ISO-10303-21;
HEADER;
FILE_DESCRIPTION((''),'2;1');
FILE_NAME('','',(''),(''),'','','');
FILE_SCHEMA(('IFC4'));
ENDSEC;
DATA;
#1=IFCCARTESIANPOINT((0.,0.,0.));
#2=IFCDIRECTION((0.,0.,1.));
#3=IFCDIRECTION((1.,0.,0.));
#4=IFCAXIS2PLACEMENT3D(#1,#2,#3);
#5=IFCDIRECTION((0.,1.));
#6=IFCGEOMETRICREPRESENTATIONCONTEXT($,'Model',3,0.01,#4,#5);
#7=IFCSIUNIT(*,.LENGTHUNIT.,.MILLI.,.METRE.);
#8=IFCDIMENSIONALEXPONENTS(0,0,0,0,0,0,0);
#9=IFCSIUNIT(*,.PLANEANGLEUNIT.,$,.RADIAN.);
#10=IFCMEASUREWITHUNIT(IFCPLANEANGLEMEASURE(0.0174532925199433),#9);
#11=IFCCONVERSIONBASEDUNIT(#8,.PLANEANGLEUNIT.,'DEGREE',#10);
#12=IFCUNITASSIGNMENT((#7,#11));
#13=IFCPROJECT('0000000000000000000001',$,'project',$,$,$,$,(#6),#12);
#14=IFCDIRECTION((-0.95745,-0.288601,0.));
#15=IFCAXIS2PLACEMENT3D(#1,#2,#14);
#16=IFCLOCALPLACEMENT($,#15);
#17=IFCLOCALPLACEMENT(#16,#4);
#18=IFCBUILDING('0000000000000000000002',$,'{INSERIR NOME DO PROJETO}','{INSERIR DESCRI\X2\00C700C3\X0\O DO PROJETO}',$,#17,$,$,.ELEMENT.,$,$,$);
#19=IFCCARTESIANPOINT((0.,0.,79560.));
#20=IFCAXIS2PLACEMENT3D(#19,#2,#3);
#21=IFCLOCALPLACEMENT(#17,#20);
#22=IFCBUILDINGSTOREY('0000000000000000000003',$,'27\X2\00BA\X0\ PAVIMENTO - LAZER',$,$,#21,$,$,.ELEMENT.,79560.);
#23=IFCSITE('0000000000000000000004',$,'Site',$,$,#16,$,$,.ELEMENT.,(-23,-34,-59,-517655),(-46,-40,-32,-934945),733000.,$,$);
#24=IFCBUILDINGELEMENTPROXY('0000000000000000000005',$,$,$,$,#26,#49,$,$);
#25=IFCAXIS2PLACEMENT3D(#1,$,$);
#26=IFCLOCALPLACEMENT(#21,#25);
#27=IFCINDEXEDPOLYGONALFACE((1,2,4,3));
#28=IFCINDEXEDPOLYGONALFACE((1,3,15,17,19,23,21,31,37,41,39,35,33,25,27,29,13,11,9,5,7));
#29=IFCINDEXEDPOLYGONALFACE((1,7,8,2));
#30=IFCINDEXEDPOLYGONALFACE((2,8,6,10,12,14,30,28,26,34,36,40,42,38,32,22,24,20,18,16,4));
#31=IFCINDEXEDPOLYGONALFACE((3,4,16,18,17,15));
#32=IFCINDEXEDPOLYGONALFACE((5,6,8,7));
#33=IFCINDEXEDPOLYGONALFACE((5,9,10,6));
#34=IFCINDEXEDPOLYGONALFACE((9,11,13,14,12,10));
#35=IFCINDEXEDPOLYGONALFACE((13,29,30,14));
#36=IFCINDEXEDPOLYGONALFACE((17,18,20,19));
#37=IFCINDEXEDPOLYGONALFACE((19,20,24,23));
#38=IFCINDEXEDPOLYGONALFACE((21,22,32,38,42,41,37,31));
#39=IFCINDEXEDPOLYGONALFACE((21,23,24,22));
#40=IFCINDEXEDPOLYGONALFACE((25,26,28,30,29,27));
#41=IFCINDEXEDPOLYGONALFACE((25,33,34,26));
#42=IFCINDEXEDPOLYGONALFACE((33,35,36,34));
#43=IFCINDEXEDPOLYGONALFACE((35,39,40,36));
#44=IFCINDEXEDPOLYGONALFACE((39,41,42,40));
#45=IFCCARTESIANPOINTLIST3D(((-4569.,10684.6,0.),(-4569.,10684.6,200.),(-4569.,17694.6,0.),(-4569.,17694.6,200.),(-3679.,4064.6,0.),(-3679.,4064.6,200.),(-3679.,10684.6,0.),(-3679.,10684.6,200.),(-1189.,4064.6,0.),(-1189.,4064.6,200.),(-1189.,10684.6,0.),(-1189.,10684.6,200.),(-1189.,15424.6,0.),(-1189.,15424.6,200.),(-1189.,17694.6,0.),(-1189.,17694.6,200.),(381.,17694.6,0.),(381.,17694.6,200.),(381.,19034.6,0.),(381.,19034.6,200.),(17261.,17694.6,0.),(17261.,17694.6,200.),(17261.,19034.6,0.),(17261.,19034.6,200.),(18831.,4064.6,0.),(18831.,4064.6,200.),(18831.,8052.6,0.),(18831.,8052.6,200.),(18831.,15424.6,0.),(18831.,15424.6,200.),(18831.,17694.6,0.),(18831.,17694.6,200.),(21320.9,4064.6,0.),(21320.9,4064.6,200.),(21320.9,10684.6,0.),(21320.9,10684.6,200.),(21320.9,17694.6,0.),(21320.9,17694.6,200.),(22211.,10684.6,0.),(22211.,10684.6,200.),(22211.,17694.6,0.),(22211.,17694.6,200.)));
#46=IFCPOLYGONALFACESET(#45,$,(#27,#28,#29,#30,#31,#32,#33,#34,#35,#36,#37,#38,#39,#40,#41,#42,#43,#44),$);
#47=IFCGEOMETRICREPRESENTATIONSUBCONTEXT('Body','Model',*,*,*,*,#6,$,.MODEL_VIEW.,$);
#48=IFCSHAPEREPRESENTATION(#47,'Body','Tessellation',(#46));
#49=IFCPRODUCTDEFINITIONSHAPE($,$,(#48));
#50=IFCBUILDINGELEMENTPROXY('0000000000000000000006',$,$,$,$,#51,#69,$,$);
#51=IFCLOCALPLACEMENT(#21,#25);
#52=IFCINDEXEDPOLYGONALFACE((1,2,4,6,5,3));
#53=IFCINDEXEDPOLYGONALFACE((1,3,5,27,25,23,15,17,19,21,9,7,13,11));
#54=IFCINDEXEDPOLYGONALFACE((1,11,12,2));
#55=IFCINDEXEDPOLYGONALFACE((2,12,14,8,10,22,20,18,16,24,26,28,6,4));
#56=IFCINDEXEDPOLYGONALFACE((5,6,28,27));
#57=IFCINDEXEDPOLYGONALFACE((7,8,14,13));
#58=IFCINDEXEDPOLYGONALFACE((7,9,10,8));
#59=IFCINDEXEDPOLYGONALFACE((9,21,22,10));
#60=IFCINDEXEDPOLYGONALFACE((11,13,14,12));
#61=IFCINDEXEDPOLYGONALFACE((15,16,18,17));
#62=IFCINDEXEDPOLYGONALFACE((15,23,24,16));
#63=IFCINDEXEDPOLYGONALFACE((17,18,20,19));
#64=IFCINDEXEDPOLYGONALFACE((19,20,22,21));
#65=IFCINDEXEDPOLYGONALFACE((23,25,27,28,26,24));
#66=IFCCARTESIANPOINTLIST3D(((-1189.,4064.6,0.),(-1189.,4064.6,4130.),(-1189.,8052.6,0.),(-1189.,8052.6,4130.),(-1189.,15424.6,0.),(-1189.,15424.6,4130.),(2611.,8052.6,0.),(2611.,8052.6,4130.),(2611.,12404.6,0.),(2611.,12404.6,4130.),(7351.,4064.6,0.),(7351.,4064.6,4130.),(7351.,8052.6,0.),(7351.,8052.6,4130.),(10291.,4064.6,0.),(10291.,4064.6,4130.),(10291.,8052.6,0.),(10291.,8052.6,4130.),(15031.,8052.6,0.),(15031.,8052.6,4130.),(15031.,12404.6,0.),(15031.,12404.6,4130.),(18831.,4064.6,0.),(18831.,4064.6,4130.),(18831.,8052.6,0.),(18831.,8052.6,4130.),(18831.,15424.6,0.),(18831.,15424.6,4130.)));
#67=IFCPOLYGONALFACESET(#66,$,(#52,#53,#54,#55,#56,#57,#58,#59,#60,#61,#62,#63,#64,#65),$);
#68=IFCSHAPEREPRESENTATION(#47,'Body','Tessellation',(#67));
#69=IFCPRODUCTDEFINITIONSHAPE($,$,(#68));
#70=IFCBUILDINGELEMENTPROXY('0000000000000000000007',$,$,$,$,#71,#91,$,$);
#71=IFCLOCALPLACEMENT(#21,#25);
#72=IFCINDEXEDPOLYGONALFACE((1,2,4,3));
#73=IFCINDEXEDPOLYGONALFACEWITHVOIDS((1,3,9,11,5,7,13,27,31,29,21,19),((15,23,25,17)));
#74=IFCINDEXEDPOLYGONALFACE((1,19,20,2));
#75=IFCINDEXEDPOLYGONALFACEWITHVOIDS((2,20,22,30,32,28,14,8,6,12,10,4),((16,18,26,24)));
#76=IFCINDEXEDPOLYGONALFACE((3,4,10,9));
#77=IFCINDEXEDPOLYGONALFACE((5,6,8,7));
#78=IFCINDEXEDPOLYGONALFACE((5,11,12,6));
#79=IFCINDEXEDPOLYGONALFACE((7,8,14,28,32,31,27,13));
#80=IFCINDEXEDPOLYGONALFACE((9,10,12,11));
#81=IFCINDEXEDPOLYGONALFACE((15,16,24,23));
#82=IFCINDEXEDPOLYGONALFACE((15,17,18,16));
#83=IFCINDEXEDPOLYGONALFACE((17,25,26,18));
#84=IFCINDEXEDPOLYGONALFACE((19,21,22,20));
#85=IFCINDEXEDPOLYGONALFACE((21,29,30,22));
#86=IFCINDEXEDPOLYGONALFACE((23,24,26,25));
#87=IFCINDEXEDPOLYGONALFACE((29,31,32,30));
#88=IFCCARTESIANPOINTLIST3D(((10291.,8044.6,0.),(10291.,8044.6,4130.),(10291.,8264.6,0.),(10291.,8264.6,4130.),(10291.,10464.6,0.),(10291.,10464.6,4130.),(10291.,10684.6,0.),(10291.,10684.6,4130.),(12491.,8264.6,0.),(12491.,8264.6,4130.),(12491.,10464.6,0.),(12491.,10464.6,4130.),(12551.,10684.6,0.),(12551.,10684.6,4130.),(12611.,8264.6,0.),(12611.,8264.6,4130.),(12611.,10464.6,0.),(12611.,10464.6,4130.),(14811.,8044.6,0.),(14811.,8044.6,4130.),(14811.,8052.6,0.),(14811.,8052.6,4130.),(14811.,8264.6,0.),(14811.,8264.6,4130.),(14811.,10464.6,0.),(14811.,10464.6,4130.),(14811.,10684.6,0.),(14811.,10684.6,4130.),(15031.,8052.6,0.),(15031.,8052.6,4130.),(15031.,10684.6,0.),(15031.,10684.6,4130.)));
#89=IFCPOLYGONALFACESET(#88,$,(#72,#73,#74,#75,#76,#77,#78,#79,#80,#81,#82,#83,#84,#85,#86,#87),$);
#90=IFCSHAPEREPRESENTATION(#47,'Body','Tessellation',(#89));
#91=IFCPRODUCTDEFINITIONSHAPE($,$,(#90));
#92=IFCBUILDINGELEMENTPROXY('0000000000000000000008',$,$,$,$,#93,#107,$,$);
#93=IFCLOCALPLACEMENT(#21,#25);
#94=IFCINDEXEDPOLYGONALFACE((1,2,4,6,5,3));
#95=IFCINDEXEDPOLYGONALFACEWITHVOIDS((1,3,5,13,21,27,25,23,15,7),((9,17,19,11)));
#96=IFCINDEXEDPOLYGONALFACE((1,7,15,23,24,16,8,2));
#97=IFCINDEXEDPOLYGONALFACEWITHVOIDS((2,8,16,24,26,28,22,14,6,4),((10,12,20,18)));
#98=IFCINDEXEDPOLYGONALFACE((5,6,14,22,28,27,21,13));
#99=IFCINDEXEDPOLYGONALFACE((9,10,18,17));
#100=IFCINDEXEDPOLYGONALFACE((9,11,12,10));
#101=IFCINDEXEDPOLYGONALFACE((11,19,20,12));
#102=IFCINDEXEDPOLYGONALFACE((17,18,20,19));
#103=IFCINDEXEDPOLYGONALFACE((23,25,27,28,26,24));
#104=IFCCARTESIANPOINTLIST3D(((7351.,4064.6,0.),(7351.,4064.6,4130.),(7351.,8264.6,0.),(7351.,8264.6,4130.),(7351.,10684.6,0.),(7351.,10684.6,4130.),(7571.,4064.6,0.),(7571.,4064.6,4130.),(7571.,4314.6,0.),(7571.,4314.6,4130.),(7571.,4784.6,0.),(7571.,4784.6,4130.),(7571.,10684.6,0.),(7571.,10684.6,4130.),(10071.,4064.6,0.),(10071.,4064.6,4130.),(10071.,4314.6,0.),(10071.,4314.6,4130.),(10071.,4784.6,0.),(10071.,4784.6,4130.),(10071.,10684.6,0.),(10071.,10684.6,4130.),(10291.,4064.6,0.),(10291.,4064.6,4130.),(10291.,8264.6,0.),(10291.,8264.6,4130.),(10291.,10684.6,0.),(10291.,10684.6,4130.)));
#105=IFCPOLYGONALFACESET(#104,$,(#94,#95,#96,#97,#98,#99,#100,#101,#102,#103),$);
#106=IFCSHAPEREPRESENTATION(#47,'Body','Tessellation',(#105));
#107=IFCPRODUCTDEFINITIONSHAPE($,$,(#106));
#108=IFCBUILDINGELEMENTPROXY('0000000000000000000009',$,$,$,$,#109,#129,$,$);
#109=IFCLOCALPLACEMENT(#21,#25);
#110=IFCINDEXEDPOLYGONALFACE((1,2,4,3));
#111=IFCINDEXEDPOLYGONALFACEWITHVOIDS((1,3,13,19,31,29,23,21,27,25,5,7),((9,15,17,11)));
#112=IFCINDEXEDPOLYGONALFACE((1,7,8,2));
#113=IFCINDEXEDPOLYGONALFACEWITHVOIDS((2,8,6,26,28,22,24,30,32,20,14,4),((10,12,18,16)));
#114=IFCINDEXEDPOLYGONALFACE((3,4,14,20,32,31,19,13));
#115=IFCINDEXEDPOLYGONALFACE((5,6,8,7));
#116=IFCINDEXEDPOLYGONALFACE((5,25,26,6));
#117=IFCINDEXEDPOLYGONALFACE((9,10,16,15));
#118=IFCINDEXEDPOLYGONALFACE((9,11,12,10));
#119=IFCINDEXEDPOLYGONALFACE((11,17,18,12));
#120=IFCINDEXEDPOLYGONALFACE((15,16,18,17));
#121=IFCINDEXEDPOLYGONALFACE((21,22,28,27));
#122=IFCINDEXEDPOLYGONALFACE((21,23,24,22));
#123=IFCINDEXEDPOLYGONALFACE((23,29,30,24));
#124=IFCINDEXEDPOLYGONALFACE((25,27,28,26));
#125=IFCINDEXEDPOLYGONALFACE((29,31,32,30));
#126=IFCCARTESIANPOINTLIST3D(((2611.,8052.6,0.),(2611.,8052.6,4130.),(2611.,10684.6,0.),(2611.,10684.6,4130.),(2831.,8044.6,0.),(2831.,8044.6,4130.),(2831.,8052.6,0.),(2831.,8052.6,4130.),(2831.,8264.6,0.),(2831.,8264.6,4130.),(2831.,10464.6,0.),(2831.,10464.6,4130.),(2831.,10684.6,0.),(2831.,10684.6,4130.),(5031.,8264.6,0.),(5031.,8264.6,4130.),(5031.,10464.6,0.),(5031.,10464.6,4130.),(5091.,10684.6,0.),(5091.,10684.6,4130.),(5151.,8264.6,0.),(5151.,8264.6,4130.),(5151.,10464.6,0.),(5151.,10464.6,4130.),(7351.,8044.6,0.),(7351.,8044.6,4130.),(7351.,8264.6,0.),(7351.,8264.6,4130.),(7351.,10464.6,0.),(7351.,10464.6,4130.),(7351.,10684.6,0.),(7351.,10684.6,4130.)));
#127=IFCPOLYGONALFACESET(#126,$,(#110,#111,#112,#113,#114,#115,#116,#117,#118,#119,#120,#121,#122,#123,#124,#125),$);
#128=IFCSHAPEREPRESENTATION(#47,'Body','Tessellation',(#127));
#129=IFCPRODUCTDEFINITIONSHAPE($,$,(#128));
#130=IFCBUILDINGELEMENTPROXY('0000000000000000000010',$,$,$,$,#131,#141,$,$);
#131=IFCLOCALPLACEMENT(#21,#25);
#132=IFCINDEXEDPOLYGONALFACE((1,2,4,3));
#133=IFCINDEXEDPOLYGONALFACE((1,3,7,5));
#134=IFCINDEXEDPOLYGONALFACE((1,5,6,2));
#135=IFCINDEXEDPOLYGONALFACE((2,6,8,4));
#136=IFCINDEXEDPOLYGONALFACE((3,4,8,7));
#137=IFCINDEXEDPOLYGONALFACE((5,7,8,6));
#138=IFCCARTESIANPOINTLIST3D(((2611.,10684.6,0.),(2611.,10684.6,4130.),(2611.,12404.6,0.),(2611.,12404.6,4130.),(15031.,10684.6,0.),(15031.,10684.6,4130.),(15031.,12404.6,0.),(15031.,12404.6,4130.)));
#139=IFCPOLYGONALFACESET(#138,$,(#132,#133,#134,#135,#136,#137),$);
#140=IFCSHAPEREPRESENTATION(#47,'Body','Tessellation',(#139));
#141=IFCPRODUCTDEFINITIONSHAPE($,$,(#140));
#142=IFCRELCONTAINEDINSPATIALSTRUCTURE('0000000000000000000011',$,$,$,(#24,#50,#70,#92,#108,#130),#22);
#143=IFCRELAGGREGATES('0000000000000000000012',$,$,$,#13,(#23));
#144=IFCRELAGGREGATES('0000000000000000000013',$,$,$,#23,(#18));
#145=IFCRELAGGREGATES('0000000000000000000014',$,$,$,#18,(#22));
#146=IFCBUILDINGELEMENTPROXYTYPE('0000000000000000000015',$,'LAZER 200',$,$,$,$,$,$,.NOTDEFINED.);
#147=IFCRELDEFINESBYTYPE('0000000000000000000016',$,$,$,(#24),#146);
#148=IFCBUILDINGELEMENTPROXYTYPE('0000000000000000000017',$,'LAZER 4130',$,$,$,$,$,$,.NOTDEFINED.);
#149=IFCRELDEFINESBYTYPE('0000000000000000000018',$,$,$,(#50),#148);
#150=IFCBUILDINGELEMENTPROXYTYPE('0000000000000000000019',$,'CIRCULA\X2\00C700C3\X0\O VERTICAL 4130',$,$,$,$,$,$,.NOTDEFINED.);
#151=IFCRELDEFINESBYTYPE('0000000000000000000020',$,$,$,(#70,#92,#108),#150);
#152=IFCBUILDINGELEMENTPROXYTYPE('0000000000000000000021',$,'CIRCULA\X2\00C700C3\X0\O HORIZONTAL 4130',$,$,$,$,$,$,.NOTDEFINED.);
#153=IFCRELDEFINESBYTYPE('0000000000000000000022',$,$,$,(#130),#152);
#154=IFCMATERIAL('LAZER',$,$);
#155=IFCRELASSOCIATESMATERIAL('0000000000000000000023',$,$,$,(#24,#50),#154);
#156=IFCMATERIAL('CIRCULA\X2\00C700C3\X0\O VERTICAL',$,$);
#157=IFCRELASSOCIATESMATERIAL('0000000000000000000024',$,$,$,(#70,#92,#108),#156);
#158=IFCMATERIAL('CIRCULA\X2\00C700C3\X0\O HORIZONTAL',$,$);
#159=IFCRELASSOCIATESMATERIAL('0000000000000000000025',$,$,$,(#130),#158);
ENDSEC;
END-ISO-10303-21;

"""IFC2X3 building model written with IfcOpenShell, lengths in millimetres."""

from ifc_helpers import new_model, entity, si_unit, converted_unit, direction, frame, origin_with_axes, place, context, subcontext, project, spatial, polyline, outline, extrude, material, type_object, element, save


model = new_model("IFC2X3")

# Units and contexts
model_context = context("Model", 3, precision=0.01, world=origin_with_axes(), true_north=direction((0.0, 1.0)))
body_context = subcontext(model_context, "Body", "Model", "MODEL_VIEW")
ifc_project = project(units=[si_unit("LENGTHUNIT", "METRE", prefix="MILLI"), converted_unit("PLANEANGLEUNIT", "DEGREE", entity("IfcPlaneAngleMeasure", 0.0174532925199433), si_unit("PLANEANGLEUNIT", "RADIAN"), dimensions=[0, 0, 0, 0, 0, 0, 0])], contexts=[model_context])

# Site, building, storey
site_placement = place(None, frame((0.0, 0.0, 0.0), z_axis=(0.0, 0.0, 1.0), x_axis=(-0.95745, -0.288601, 0.0)))
site = spatial("IfcSite", under=ifc_project, at=site_placement, Name="Site", CompositionType="ELEMENT", RefLatitude=(-23, -34, -59, -517655), RefLongitude=(-46, -40, -32, -934945), RefElevation=733000.0)
building_placement = place(site_placement, origin_with_axes())
building = spatial("IfcBuilding", under=site, at=building_placement, Name="{INSERIR NOME DO PROJETO}", Description="{INSERIR DESCRIÇÃO DO PROJETO}", CompositionType="ELEMENT")
storey_placement = place(building_placement, frame((0.0, 0.0, 79560.0), z_axis=(0.0, 0.0, 1.0), x_axis=(1.0, 0.0, 0.0)))
storey = spatial("IfcBuildingStorey", under=building, at=storey_placement, Name="27º PAVIMENTO - LAZER", CompositionType="ELEMENT", Elevation=79560.0)

# Building element proxies
ifc_material_1 = material(Name="LAZER")
building_element_proxy_type_1 = type_object("IfcBuildingElementProxyType", Name="LAZER 200", PredefinedType="NOTDEFINED")
proxy_1_placement = place(storey_placement, frame((-4569.0, 17694.6, 0.0), z_axis=(0.0, 0.0, 1.0), x_axis=(1.0, 0.0, 0.0)))
element("IfcBuildingElementProxy", 1, at=proxy_1_placement, inside=storey, type_object=building_element_proxy_type_1, material=ifc_material_1, context=body_context, shape_type="SweptSolid", body=[
    extrude(outline(polyline([(0.0, 0.0), (0.0, -7010.0), (890.0, -7010.0), (890.0, -13630.0), (3380.0, -13630.0), (3380.0, -7010.0), (3380.0, -2270.0), (23400.0, -2270.0), (23400.0, -9642.0), (23400.0, -13630.0), (25890.0, -13630.0), (25890.0, -7010.0), (26780.0, -7010.0), (26780.0, 0.0), (25890.0, 0.0), (23400.0, 0.0), (21830.0, 0.0), (21830.0, 1340.0), (4950.0, 1340.0), (4950.0, 0.0), (3380.0, 0.0), (0.0, 0.0)])), origin_with_axes(), (0.0, 0.0, 1.0), 200.0),
])
building_element_proxy_type_2 = type_object("IfcBuildingElementProxyType", Name="LAZER 4130", PredefinedType="NOTDEFINED")
proxy_2_placement = place(storey_placement, frame((-1189.0, 15424.6, 0.0), z_axis=(0.0, 0.0, 1.0), x_axis=(1.0, 0.0, 0.0)))
element("IfcBuildingElementProxy", 2, at=proxy_2_placement, inside=storey, type_object=building_element_proxy_type_2, material=ifc_material_1, context=body_context, shape_type="SweptSolid", body=[
    extrude(outline(polyline([(0.0, 0.0), (0.0, -7372.1), (0.0, -11360.0), (8540.0, -11360.0), (8540.0, -7372.1), (3800.0, -7372.1), (3800.0, -3020.0), (16220.0, -3020.0), (16220.0, -7372.1), (11480.0, -7372.1), (11480.0, -11360.0), (20020.0, -11360.0), (20020.0, -7372.1), (20020.0, 0.0), (0.0, 0.0)])), origin_with_axes(), (0.0, 0.0, 1.0), 4130.0),
])
ifc_material_2 = material(Name="CIRCULAÇÃO VERTICAL")
building_element_proxy_type_3 = type_object("IfcBuildingElementProxyType", Name="CIRCULAÇÃO VERTICAL 4130", PredefinedType="NOTDEFINED")
proxy_3_placement = place(storey_placement, frame((10291.0, 10464.6, 0.0), z_axis=(0.0, 0.0, 1.0), x_axis=(1.0, 0.0, 0.0)))
element("IfcBuildingElementProxy", 3, at=proxy_3_placement, inside=storey, type_object=building_element_proxy_type_3, material=ifc_material_2, context=body_context, shape_type="SweptSolid", body=[
    extrude(outline(polyline([(0.0, 0.0), (2200.0, 0.0), (2200.0, -2200.0), (0.0, -2200.0), (0.0, -2420.0), (4520.0, -2420.0), (4520.0, -2412.1), (4740.0, -2412.1), (4740.0, 220.0), (4520.0, 220.0), (2260.0, 220.0), (0.0, 220.0), (0.0, 0.0)]), holes=[polyline([(2320.0, 0.0), (4520.0, 0.0), (4520.0, -2200.0), (2320.0, -2200.0), (2320.0, 0.0)])]), origin_with_axes(), (0.0, 0.0, 1.0), 4130.0),
])
proxy_4_placement = place(storey_placement, frame((7571.0, 10684.6, 0.0), z_axis=(0.0, 0.0, 1.0), x_axis=(1.0, 0.0, 0.0)))
element("IfcBuildingElementProxy", 4, at=proxy_4_placement, inside=storey, type_object=building_element_proxy_type_3, material=ifc_material_2, context=body_context, shape_type="SweptSolid", body=[
    extrude(outline(polyline([(0.0, 0.0), (-220.0, 0.0), (-220.0, -2420.0), (-220.0, -6620.0), (0.0, -6620.0), (2500.0, -6620.0), (2720.0, -6620.0), (2720.0, -2420.0), (2720.0, 0.0), (2500.0, 0.0), (0.0, 0.0)]), holes=[polyline([(2500.0, -6370.0), (0.0, -6370.0), (0.0, -5900.0), (2500.0, -5900.0), (2500.0, -6370.0)])]), origin_with_axes(), (0.0, 0.0, 1.0), 4130.0),
])
proxy_5_placement = place(storey_placement, frame((7351.0, 10464.6, 0.0), z_axis=(0.0, 0.0, 1.0), x_axis=(1.0, 0.0, 0.0)))
element("IfcBuildingElementProxy", 5, at=proxy_5_placement, inside=storey, type_object=building_element_proxy_type_3, material=ifc_material_2, context=body_context, shape_type="SweptSolid", body=[
    extrude(outline(polyline([(0.0, 0.0), (0.0, 220.0), (-2260.0, 220.0), (-4520.0, 220.0), (-4740.0, 220.0), (-4740.0, -2412.1), (-4520.0, -2412.1), (-4520.0, -2420.0), (0.0, -2420.0), (0.0, -2200.0), (-2200.0, -2200.0), (-2200.0, 0.0), (0.0, 0.0)]), holes=[polyline([(-2320.0, 0.0), (-2320.0, -2200.0), (-4520.0, -2200.0), (-4520.0, 0.0), (-2320.0, 0.0)])]), origin_with_axes(), (0.0, 0.0, 1.0), 4130.0),
])
ifc_material_3 = material(Name="CIRCULAÇÃO HORIZONTAL")
building_element_proxy_type_4 = type_object("IfcBuildingElementProxyType", Name="CIRCULAÇÃO HORIZONTAL 4130", PredefinedType="NOTDEFINED")
proxy_6_placement = place(storey_placement, frame((2611.0, 10684.6, 0.0), z_axis=(0.0, 0.0, 1.0), x_axis=(1.0, 0.0, 0.0)))
element("IfcBuildingElementProxy", 6, at=proxy_6_placement, inside=storey, type_object=building_element_proxy_type_4, material=ifc_material_3, context=body_context, shape_type="SweptSolid", body=[
    extrude(outline(polyline([(0.0, 0.0), (12420.0, 0.0), (12420.0, 1720.0), (0.0, 1720.0), (0.0, 0.0)])), origin_with_axes(), (0.0, 0.0, 1.0), 4130.0),
])

save(model, "model.ifc")
